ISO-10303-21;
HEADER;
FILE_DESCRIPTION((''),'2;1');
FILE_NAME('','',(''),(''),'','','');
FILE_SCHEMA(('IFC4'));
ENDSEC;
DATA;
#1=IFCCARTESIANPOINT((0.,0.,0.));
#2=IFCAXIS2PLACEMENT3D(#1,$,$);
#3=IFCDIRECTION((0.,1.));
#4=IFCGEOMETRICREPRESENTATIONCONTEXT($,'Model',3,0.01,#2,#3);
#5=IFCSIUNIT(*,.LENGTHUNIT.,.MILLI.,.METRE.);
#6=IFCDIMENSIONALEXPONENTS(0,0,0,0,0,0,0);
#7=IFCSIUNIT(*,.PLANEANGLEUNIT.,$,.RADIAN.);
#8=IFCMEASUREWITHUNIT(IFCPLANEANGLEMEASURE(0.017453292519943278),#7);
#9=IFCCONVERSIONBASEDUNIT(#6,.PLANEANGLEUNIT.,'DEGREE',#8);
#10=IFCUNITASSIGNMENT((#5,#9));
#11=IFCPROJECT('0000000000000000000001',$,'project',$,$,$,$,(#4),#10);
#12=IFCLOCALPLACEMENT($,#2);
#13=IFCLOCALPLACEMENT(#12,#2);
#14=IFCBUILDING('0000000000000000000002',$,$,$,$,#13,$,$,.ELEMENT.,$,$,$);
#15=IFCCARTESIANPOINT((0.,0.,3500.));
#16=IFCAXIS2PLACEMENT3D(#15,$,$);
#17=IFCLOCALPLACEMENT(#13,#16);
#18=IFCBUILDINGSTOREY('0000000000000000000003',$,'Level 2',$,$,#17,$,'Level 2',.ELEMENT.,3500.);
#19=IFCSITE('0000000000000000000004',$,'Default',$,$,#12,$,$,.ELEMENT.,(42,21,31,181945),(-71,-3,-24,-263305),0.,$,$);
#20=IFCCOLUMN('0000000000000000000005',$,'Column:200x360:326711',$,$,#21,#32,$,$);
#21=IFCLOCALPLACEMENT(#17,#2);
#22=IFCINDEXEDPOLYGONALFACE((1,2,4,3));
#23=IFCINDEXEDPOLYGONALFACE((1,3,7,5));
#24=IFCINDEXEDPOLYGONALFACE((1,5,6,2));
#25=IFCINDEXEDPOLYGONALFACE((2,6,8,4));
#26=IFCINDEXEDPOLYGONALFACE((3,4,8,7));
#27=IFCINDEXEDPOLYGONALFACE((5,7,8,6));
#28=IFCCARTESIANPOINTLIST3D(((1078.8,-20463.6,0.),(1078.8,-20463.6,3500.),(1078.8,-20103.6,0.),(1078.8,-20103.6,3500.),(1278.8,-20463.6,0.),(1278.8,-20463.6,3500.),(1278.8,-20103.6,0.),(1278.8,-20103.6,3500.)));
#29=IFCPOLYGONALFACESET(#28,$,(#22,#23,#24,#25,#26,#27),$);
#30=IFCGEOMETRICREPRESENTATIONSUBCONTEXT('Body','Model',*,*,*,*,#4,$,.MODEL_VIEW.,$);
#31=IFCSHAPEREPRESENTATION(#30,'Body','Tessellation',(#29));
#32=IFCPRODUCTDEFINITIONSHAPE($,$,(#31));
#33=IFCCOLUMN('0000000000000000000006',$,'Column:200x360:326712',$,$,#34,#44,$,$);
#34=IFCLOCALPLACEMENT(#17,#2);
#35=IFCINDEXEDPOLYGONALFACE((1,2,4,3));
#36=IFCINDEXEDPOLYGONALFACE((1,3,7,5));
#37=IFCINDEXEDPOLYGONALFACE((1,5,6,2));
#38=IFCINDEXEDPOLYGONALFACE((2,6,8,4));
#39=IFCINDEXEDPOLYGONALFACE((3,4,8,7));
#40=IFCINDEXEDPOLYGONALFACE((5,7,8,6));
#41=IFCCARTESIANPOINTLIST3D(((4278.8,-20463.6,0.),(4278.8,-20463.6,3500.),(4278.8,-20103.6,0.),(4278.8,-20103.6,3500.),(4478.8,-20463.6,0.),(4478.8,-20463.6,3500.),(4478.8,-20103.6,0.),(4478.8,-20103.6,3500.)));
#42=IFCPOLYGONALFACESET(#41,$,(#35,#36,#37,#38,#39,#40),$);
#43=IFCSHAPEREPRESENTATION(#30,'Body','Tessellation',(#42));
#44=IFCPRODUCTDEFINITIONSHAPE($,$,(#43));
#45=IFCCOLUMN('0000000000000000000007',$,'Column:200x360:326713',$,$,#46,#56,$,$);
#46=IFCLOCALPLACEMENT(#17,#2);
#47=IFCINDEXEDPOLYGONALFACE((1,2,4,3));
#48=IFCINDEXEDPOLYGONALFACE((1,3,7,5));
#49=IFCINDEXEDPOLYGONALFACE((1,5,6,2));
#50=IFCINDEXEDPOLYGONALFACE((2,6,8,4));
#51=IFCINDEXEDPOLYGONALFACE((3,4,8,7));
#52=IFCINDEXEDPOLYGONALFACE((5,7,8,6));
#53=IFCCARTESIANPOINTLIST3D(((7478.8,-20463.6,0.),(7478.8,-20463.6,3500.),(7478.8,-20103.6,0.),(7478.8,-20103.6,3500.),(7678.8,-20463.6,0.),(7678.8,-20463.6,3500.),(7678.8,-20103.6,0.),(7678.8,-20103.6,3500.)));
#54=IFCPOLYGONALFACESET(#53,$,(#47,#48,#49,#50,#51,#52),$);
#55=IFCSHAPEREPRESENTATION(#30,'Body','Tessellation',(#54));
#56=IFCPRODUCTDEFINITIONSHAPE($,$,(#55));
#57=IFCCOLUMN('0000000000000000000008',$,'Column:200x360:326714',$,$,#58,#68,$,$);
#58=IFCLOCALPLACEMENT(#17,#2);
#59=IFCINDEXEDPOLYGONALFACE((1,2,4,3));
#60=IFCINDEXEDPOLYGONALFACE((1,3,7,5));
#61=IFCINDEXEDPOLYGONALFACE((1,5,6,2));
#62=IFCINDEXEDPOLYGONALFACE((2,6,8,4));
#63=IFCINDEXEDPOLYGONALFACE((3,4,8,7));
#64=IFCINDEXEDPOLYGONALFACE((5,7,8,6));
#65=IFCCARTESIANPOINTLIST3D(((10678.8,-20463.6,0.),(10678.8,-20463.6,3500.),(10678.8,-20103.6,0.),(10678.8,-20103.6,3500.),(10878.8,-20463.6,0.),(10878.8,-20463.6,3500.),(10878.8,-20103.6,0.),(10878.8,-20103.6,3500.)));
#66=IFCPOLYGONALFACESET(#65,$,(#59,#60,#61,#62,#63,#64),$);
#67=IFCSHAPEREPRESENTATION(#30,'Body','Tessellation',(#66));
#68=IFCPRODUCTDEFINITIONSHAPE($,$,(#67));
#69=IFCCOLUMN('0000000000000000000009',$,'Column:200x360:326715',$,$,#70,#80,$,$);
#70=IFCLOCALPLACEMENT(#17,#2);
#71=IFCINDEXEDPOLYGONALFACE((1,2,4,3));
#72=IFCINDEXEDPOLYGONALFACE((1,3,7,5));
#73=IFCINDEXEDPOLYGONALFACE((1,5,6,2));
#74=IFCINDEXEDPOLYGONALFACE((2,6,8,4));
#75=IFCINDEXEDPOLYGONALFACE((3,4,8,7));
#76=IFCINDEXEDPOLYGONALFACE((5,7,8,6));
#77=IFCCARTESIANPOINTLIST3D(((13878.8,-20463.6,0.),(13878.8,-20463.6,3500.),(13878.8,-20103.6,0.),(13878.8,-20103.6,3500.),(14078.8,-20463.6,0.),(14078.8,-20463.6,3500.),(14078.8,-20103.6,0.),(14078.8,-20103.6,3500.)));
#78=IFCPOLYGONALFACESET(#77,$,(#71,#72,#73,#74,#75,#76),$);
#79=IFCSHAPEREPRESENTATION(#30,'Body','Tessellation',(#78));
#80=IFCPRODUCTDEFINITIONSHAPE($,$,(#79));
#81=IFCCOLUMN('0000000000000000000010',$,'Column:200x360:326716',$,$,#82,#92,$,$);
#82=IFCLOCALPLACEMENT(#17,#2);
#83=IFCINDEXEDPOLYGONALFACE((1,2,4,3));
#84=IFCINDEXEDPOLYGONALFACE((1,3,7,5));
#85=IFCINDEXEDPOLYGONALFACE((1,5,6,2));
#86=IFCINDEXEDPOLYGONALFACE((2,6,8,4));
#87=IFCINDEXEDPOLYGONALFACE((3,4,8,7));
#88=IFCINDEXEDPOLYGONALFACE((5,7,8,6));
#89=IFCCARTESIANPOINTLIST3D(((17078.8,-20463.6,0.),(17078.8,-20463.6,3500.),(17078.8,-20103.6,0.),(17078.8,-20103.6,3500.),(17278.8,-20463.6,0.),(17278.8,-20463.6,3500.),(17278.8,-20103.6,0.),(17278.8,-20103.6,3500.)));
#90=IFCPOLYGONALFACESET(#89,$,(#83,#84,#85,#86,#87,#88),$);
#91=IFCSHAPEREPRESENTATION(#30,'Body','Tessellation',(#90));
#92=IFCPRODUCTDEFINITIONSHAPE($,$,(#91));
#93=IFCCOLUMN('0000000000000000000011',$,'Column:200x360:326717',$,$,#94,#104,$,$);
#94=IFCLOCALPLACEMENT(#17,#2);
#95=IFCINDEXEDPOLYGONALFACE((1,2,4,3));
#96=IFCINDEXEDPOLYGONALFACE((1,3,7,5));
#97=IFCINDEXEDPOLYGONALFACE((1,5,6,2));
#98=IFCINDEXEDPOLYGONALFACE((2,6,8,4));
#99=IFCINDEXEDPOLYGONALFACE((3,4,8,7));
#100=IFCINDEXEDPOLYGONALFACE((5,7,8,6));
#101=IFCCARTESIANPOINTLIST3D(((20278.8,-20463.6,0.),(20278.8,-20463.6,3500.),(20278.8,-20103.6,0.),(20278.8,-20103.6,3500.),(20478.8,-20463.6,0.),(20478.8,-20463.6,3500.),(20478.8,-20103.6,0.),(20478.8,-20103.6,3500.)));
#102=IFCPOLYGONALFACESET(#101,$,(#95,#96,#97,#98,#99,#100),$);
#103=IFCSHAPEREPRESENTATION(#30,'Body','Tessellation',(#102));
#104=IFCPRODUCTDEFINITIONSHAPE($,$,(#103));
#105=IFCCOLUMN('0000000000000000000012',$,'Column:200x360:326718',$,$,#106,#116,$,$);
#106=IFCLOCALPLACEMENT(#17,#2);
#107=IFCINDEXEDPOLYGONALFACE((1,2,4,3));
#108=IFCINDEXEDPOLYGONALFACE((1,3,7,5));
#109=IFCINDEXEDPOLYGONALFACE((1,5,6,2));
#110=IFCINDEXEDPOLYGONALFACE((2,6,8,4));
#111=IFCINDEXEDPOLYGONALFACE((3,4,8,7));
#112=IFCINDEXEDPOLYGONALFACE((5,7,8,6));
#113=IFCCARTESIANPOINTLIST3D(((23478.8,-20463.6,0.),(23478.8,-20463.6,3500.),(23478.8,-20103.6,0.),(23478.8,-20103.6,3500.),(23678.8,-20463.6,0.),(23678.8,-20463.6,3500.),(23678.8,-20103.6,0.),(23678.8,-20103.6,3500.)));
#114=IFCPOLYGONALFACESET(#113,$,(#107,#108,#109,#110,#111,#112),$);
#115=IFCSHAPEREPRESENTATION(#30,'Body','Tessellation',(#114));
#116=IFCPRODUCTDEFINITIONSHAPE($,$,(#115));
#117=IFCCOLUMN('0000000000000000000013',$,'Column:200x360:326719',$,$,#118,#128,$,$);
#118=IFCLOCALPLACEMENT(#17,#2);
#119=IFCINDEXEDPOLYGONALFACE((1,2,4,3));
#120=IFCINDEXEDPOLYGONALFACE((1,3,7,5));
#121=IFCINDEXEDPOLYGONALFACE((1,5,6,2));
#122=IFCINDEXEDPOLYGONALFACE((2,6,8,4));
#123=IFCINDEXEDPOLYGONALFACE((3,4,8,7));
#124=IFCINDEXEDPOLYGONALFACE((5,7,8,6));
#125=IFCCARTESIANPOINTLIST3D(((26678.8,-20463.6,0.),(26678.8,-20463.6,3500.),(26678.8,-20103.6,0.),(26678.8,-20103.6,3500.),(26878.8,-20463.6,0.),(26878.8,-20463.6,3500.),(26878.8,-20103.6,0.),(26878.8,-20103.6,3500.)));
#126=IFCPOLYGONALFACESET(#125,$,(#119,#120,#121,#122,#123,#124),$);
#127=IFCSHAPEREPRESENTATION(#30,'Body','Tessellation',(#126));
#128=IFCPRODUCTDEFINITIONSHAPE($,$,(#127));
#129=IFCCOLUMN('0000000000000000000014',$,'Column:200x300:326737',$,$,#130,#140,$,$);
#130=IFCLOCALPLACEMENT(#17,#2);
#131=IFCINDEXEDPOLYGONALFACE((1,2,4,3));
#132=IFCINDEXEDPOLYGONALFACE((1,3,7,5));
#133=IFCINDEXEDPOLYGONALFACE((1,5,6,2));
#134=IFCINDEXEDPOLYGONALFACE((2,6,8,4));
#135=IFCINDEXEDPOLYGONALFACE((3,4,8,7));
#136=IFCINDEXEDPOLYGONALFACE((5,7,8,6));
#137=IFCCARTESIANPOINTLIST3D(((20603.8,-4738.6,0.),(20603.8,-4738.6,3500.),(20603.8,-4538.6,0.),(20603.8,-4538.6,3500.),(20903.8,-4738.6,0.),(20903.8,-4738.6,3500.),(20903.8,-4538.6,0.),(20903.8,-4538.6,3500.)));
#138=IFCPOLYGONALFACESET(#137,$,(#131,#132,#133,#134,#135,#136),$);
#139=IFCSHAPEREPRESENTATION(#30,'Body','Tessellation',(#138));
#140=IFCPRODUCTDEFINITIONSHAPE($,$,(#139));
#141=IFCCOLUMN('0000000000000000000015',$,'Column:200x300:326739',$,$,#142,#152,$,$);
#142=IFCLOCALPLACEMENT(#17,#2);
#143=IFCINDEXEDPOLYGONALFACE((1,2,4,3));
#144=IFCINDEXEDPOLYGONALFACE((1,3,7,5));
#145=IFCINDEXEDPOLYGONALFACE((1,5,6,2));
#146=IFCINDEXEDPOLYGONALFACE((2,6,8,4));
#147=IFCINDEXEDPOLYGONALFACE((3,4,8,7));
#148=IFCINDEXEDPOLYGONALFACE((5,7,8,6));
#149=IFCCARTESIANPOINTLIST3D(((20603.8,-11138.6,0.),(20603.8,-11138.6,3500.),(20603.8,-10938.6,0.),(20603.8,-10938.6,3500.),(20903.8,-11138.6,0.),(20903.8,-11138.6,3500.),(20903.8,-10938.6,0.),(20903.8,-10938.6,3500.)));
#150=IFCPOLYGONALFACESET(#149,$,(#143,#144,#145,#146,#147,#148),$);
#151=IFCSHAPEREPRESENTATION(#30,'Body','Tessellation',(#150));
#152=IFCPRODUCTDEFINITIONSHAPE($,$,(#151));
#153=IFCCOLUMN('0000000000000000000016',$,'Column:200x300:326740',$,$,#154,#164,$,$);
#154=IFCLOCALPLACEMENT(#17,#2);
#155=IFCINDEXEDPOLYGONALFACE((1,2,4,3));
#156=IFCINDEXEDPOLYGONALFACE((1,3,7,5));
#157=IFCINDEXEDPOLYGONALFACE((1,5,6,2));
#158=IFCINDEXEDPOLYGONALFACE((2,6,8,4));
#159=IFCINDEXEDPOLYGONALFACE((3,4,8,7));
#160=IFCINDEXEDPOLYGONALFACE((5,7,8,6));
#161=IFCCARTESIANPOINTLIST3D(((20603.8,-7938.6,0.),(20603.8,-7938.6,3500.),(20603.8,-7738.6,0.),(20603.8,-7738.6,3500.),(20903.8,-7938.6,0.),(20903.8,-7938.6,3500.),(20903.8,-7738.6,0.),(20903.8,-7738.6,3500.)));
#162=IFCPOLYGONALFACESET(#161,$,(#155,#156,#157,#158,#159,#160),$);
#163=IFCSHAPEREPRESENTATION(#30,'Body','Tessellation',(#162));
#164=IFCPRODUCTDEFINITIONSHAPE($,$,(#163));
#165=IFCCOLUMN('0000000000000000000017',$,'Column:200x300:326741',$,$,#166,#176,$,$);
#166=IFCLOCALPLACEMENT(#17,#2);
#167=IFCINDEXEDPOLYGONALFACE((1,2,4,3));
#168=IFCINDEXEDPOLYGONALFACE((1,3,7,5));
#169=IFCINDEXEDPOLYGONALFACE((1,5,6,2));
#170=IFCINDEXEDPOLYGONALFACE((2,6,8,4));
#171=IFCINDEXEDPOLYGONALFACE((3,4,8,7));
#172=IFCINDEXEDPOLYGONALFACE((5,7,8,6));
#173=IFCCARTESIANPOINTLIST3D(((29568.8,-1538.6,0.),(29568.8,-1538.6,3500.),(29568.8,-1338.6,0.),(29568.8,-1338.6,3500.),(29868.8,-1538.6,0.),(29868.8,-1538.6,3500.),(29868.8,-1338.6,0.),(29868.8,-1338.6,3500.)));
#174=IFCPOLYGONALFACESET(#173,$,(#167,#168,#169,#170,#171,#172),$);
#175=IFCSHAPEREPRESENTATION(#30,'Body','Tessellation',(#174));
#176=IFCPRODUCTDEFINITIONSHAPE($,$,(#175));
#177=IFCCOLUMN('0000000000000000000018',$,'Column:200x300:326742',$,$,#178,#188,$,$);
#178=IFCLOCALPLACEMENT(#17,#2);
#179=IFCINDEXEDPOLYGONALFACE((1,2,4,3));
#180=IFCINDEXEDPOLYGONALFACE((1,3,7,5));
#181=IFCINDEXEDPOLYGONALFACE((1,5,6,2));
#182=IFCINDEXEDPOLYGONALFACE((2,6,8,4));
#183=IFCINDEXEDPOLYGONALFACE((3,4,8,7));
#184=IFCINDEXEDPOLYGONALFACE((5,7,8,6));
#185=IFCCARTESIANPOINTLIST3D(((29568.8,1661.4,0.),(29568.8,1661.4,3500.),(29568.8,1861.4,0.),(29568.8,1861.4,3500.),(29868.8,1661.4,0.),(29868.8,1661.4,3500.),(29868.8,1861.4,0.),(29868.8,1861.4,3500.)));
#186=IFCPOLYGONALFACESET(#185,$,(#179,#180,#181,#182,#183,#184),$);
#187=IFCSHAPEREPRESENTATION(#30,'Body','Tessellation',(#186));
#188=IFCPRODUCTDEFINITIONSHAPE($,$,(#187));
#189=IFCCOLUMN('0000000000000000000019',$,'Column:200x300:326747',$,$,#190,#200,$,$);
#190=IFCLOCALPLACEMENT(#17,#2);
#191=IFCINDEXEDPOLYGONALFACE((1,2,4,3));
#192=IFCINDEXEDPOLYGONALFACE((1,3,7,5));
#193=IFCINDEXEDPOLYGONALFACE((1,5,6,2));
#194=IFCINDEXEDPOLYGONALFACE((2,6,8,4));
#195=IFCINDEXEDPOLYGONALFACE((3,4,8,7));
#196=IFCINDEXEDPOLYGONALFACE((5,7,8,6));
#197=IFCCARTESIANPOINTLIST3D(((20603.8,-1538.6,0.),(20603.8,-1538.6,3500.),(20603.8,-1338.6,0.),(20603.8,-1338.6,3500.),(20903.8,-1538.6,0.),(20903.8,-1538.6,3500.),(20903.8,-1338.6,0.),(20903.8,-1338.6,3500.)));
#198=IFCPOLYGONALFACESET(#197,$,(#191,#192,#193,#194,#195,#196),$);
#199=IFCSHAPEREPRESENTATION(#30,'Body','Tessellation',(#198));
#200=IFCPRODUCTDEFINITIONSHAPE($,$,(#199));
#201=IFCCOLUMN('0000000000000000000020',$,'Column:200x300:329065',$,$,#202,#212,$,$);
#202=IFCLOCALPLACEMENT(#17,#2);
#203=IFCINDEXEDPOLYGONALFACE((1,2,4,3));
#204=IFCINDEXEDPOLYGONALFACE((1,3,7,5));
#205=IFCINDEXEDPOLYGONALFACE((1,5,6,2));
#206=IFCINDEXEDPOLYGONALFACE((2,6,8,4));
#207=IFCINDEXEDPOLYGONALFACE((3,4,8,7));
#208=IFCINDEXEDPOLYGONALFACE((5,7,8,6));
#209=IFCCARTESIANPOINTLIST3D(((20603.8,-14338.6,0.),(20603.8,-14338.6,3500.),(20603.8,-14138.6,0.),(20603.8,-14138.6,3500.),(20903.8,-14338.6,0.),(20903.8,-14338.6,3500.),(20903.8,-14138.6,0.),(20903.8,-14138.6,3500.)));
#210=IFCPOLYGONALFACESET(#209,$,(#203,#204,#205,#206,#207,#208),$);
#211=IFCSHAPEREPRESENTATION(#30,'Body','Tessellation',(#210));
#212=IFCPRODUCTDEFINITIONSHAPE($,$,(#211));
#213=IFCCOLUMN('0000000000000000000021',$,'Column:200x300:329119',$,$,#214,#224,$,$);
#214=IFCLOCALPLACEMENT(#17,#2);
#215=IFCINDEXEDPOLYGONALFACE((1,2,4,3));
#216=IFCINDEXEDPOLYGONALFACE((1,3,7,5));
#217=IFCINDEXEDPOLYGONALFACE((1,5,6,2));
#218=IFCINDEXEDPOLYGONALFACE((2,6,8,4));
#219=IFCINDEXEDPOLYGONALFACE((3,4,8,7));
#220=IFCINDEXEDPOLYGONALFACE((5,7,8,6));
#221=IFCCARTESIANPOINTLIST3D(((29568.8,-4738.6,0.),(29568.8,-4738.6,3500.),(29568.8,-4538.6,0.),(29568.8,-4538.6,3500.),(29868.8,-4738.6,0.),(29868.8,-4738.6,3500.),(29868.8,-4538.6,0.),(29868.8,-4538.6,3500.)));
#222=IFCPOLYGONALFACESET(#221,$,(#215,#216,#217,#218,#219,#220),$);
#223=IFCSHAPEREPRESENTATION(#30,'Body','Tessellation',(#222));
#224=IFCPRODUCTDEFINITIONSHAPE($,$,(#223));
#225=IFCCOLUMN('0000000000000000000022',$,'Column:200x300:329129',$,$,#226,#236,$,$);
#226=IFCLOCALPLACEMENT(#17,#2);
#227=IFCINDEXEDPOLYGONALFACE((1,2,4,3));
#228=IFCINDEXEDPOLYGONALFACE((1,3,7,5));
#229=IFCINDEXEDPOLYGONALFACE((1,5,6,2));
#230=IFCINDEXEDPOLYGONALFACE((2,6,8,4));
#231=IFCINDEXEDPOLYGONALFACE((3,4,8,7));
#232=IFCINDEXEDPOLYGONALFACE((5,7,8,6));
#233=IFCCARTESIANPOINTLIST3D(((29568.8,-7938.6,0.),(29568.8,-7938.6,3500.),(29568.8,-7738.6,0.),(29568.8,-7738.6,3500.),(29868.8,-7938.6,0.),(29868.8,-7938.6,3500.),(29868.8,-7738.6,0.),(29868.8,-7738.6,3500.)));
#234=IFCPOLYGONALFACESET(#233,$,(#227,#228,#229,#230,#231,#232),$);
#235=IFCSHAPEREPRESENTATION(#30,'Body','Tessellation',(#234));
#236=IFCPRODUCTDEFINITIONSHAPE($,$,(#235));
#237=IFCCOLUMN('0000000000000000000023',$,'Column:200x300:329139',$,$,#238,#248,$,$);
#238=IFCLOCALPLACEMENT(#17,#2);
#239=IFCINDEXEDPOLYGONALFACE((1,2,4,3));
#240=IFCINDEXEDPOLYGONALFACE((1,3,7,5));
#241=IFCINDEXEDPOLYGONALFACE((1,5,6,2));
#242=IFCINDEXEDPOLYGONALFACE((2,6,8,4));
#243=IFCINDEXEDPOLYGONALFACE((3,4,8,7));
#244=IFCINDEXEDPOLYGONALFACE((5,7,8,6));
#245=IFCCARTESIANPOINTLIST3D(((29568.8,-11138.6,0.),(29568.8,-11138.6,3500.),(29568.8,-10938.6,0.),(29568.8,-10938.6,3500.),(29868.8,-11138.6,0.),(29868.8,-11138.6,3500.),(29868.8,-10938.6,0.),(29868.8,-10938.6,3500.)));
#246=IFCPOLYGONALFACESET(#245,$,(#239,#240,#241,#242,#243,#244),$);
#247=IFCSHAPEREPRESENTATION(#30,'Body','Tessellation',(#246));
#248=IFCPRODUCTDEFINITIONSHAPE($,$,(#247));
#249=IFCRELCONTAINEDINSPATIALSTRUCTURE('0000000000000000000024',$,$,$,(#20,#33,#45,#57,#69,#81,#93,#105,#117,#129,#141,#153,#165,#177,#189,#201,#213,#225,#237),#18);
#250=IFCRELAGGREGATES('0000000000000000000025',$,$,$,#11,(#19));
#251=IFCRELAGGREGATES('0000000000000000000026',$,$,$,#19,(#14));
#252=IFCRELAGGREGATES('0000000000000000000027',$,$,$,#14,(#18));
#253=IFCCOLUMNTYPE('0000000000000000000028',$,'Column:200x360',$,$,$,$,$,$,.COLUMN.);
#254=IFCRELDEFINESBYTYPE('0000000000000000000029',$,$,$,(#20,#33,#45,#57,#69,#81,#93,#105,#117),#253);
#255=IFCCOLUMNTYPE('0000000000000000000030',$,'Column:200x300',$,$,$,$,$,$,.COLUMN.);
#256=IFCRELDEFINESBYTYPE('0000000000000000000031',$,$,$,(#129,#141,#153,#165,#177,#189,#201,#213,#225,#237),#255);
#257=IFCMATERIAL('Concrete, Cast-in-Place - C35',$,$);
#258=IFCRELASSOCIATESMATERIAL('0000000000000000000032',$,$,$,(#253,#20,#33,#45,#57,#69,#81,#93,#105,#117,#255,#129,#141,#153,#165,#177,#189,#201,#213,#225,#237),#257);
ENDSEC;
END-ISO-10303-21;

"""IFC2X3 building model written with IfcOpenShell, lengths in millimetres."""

from ifc_helpers import new_model, entity, si_unit, converted_unit, direction, frame, frame_2d, origin, origin_2d_with_axis, place, context, subcontext, project, spatial, rectangle, extrude, source, transform, mapped, material, type_object, type_shapes, element, save


model = new_model("IFC2X3")

# Units and contexts
model_context = context("Model", 3, precision=0.01, world=origin(), true_north=direction((0.0, 1.0)))
body_context = subcontext(model_context, "Body", "Model", "MODEL_VIEW")
ifc_project = project(units=[si_unit("LENGTHUNIT", "METRE", prefix="MILLI"), converted_unit("PLANEANGLEUNIT", "DEGREE", entity("IfcPlaneAngleMeasure", 0.017453292519943278), si_unit("PLANEANGLEUNIT", "RADIAN"), dimensions=[0, 0, 0, 0, 0, 0, 0])], contexts=[model_context])

# Site, building, storey
site_placement = place(None, origin())
site = spatial("IfcSite", under=ifc_project, at=site_placement, Name="Default", CompositionType="ELEMENT", RefLatitude=(42, 21, 31, 181945), RefLongitude=(-71, -3, -24, -263305), RefElevation=0.0)
building_placement = place(site_placement, origin())
building = spatial("IfcBuilding", under=site, at=building_placement, CompositionType="ELEMENT")
storey_placement = place(building_placement, frame((0.0, 0.0, 3500.0)))
storey = spatial("IfcBuildingStorey", under=building, at=storey_placement, Name="Level 2", LongName="Level 2", CompositionType="ELEMENT", Elevation=3500.0)

# Columns
ifc_material_1 = material(Name="Concrete, Cast-in-Place - C35")
column_type_1 = type_object("IfcColumnType", Name="Column:200x360", PredefinedType="COLUMN", material=ifc_material_1)
shared_shape_1 = source(origin(), body_context, "Body", "SweptSolid", [
    extrude(rectangle(XDim=200.0, YDim=360.0, at=frame_2d((0.0, 0.0), x_axis=(1.0, 0.0))), frame((0.0, 80.0, 3500.0), z_axis=(0.0, 0.0, 1.0), x_axis=(-1.0, 0.0, 0.0)), (0.0, 0.0, 1.0), 3500.0),
])
type_shapes(column_type_1, [shared_shape_1])
for number, where, name in (
    (1, (1178.8, -20363.6, -3500.0), "Column:200x360:326711"),
    (2, (4378.8, -20363.6, -3500.0), "Column:200x360:326712"),
    (3, (7578.8, -20363.6, -3500.0), "Column:200x360:326713"),
    (4, (10778.8, -20363.6, -3500.0), "Column:200x360:326714"),
    (5, (13978.8, -20363.6, -3500.0), "Column:200x360:326715"),
    (6, (17178.8, -20363.6, -3500.0), "Column:200x360:326716"),
    (7, (20378.8, -20363.6, -3500.0), "Column:200x360:326717"),
    (8, (23578.8, -20363.6, -3500.0), "Column:200x360:326718"),
    (9, (26778.8, -20363.6, -3500.0), "Column:200x360:326719"),
):
    element("IfcColumn", number, at=place(storey_placement, frame(where)), inside=storey, type_object=column_type_1, material=ifc_material_1, Name=name, context=body_context, shape_type="MappedRepresentation", body=[
        mapped(shared_shape_1, transform((0.0, 0.0, 0.0), scale=1.0)),
    ])
column_type_2 = type_object("IfcColumnType", Name="Column:200x300", PredefinedType="COLUMN", material=ifc_material_1)
shared_shape_2 = source(origin(), body_context, "Body", "SweptSolid", [
    extrude(rectangle(XDim=300.0, YDim=200.0, at=origin_2d_with_axis()), frame((-50.0, 0.0, 3500.0), z_axis=(0.0, 0.0, 1.0), x_axis=(-1.0, 0.0, 0.0)), (0.0, 0.0, 1.0), 3500.0),
])
type_shapes(column_type_2, [shared_shape_2])
for number, where, name in (
    (10, (20803.8, -4638.6, -3500.0), "Column:200x300:326737"),
    (11, (20803.8, -11038.6, -3500.0), "Column:200x300:326739"),
    (12, (20803.8, -7838.6, -3500.0), "Column:200x300:326740"),
    (13, (29768.8, -1438.6, -3500.0), "Column:200x300:326741"),
    (14, (29768.8, 1761.4, -3500.0), "Column:200x300:326742"),
    (15, (20803.8, -1438.6, -3500.0), "Column:200x300:326747"),
    (16, (20803.8, -14238.6, -3500.0), "Column:200x300:329065"),
    (17, (29768.8, -4638.6, -3500.0), "Column:200x300:329119"),
    (18, (29768.8, -7838.6, -3500.0), "Column:200x300:329129"),
    (19, (29768.8, -11038.6, -3500.0), "Column:200x300:329139"),
):
    element("IfcColumn", number, at=place(storey_placement, frame(where)), inside=storey, type_object=column_type_2, material=ifc_material_1, Name=name, context=body_context, shape_type="MappedRepresentation", body=[
        mapped(shared_shape_2, transform((0.0, 0.0, 0.0), scale=1.0)),
    ])

save(model, "model.ifc")
